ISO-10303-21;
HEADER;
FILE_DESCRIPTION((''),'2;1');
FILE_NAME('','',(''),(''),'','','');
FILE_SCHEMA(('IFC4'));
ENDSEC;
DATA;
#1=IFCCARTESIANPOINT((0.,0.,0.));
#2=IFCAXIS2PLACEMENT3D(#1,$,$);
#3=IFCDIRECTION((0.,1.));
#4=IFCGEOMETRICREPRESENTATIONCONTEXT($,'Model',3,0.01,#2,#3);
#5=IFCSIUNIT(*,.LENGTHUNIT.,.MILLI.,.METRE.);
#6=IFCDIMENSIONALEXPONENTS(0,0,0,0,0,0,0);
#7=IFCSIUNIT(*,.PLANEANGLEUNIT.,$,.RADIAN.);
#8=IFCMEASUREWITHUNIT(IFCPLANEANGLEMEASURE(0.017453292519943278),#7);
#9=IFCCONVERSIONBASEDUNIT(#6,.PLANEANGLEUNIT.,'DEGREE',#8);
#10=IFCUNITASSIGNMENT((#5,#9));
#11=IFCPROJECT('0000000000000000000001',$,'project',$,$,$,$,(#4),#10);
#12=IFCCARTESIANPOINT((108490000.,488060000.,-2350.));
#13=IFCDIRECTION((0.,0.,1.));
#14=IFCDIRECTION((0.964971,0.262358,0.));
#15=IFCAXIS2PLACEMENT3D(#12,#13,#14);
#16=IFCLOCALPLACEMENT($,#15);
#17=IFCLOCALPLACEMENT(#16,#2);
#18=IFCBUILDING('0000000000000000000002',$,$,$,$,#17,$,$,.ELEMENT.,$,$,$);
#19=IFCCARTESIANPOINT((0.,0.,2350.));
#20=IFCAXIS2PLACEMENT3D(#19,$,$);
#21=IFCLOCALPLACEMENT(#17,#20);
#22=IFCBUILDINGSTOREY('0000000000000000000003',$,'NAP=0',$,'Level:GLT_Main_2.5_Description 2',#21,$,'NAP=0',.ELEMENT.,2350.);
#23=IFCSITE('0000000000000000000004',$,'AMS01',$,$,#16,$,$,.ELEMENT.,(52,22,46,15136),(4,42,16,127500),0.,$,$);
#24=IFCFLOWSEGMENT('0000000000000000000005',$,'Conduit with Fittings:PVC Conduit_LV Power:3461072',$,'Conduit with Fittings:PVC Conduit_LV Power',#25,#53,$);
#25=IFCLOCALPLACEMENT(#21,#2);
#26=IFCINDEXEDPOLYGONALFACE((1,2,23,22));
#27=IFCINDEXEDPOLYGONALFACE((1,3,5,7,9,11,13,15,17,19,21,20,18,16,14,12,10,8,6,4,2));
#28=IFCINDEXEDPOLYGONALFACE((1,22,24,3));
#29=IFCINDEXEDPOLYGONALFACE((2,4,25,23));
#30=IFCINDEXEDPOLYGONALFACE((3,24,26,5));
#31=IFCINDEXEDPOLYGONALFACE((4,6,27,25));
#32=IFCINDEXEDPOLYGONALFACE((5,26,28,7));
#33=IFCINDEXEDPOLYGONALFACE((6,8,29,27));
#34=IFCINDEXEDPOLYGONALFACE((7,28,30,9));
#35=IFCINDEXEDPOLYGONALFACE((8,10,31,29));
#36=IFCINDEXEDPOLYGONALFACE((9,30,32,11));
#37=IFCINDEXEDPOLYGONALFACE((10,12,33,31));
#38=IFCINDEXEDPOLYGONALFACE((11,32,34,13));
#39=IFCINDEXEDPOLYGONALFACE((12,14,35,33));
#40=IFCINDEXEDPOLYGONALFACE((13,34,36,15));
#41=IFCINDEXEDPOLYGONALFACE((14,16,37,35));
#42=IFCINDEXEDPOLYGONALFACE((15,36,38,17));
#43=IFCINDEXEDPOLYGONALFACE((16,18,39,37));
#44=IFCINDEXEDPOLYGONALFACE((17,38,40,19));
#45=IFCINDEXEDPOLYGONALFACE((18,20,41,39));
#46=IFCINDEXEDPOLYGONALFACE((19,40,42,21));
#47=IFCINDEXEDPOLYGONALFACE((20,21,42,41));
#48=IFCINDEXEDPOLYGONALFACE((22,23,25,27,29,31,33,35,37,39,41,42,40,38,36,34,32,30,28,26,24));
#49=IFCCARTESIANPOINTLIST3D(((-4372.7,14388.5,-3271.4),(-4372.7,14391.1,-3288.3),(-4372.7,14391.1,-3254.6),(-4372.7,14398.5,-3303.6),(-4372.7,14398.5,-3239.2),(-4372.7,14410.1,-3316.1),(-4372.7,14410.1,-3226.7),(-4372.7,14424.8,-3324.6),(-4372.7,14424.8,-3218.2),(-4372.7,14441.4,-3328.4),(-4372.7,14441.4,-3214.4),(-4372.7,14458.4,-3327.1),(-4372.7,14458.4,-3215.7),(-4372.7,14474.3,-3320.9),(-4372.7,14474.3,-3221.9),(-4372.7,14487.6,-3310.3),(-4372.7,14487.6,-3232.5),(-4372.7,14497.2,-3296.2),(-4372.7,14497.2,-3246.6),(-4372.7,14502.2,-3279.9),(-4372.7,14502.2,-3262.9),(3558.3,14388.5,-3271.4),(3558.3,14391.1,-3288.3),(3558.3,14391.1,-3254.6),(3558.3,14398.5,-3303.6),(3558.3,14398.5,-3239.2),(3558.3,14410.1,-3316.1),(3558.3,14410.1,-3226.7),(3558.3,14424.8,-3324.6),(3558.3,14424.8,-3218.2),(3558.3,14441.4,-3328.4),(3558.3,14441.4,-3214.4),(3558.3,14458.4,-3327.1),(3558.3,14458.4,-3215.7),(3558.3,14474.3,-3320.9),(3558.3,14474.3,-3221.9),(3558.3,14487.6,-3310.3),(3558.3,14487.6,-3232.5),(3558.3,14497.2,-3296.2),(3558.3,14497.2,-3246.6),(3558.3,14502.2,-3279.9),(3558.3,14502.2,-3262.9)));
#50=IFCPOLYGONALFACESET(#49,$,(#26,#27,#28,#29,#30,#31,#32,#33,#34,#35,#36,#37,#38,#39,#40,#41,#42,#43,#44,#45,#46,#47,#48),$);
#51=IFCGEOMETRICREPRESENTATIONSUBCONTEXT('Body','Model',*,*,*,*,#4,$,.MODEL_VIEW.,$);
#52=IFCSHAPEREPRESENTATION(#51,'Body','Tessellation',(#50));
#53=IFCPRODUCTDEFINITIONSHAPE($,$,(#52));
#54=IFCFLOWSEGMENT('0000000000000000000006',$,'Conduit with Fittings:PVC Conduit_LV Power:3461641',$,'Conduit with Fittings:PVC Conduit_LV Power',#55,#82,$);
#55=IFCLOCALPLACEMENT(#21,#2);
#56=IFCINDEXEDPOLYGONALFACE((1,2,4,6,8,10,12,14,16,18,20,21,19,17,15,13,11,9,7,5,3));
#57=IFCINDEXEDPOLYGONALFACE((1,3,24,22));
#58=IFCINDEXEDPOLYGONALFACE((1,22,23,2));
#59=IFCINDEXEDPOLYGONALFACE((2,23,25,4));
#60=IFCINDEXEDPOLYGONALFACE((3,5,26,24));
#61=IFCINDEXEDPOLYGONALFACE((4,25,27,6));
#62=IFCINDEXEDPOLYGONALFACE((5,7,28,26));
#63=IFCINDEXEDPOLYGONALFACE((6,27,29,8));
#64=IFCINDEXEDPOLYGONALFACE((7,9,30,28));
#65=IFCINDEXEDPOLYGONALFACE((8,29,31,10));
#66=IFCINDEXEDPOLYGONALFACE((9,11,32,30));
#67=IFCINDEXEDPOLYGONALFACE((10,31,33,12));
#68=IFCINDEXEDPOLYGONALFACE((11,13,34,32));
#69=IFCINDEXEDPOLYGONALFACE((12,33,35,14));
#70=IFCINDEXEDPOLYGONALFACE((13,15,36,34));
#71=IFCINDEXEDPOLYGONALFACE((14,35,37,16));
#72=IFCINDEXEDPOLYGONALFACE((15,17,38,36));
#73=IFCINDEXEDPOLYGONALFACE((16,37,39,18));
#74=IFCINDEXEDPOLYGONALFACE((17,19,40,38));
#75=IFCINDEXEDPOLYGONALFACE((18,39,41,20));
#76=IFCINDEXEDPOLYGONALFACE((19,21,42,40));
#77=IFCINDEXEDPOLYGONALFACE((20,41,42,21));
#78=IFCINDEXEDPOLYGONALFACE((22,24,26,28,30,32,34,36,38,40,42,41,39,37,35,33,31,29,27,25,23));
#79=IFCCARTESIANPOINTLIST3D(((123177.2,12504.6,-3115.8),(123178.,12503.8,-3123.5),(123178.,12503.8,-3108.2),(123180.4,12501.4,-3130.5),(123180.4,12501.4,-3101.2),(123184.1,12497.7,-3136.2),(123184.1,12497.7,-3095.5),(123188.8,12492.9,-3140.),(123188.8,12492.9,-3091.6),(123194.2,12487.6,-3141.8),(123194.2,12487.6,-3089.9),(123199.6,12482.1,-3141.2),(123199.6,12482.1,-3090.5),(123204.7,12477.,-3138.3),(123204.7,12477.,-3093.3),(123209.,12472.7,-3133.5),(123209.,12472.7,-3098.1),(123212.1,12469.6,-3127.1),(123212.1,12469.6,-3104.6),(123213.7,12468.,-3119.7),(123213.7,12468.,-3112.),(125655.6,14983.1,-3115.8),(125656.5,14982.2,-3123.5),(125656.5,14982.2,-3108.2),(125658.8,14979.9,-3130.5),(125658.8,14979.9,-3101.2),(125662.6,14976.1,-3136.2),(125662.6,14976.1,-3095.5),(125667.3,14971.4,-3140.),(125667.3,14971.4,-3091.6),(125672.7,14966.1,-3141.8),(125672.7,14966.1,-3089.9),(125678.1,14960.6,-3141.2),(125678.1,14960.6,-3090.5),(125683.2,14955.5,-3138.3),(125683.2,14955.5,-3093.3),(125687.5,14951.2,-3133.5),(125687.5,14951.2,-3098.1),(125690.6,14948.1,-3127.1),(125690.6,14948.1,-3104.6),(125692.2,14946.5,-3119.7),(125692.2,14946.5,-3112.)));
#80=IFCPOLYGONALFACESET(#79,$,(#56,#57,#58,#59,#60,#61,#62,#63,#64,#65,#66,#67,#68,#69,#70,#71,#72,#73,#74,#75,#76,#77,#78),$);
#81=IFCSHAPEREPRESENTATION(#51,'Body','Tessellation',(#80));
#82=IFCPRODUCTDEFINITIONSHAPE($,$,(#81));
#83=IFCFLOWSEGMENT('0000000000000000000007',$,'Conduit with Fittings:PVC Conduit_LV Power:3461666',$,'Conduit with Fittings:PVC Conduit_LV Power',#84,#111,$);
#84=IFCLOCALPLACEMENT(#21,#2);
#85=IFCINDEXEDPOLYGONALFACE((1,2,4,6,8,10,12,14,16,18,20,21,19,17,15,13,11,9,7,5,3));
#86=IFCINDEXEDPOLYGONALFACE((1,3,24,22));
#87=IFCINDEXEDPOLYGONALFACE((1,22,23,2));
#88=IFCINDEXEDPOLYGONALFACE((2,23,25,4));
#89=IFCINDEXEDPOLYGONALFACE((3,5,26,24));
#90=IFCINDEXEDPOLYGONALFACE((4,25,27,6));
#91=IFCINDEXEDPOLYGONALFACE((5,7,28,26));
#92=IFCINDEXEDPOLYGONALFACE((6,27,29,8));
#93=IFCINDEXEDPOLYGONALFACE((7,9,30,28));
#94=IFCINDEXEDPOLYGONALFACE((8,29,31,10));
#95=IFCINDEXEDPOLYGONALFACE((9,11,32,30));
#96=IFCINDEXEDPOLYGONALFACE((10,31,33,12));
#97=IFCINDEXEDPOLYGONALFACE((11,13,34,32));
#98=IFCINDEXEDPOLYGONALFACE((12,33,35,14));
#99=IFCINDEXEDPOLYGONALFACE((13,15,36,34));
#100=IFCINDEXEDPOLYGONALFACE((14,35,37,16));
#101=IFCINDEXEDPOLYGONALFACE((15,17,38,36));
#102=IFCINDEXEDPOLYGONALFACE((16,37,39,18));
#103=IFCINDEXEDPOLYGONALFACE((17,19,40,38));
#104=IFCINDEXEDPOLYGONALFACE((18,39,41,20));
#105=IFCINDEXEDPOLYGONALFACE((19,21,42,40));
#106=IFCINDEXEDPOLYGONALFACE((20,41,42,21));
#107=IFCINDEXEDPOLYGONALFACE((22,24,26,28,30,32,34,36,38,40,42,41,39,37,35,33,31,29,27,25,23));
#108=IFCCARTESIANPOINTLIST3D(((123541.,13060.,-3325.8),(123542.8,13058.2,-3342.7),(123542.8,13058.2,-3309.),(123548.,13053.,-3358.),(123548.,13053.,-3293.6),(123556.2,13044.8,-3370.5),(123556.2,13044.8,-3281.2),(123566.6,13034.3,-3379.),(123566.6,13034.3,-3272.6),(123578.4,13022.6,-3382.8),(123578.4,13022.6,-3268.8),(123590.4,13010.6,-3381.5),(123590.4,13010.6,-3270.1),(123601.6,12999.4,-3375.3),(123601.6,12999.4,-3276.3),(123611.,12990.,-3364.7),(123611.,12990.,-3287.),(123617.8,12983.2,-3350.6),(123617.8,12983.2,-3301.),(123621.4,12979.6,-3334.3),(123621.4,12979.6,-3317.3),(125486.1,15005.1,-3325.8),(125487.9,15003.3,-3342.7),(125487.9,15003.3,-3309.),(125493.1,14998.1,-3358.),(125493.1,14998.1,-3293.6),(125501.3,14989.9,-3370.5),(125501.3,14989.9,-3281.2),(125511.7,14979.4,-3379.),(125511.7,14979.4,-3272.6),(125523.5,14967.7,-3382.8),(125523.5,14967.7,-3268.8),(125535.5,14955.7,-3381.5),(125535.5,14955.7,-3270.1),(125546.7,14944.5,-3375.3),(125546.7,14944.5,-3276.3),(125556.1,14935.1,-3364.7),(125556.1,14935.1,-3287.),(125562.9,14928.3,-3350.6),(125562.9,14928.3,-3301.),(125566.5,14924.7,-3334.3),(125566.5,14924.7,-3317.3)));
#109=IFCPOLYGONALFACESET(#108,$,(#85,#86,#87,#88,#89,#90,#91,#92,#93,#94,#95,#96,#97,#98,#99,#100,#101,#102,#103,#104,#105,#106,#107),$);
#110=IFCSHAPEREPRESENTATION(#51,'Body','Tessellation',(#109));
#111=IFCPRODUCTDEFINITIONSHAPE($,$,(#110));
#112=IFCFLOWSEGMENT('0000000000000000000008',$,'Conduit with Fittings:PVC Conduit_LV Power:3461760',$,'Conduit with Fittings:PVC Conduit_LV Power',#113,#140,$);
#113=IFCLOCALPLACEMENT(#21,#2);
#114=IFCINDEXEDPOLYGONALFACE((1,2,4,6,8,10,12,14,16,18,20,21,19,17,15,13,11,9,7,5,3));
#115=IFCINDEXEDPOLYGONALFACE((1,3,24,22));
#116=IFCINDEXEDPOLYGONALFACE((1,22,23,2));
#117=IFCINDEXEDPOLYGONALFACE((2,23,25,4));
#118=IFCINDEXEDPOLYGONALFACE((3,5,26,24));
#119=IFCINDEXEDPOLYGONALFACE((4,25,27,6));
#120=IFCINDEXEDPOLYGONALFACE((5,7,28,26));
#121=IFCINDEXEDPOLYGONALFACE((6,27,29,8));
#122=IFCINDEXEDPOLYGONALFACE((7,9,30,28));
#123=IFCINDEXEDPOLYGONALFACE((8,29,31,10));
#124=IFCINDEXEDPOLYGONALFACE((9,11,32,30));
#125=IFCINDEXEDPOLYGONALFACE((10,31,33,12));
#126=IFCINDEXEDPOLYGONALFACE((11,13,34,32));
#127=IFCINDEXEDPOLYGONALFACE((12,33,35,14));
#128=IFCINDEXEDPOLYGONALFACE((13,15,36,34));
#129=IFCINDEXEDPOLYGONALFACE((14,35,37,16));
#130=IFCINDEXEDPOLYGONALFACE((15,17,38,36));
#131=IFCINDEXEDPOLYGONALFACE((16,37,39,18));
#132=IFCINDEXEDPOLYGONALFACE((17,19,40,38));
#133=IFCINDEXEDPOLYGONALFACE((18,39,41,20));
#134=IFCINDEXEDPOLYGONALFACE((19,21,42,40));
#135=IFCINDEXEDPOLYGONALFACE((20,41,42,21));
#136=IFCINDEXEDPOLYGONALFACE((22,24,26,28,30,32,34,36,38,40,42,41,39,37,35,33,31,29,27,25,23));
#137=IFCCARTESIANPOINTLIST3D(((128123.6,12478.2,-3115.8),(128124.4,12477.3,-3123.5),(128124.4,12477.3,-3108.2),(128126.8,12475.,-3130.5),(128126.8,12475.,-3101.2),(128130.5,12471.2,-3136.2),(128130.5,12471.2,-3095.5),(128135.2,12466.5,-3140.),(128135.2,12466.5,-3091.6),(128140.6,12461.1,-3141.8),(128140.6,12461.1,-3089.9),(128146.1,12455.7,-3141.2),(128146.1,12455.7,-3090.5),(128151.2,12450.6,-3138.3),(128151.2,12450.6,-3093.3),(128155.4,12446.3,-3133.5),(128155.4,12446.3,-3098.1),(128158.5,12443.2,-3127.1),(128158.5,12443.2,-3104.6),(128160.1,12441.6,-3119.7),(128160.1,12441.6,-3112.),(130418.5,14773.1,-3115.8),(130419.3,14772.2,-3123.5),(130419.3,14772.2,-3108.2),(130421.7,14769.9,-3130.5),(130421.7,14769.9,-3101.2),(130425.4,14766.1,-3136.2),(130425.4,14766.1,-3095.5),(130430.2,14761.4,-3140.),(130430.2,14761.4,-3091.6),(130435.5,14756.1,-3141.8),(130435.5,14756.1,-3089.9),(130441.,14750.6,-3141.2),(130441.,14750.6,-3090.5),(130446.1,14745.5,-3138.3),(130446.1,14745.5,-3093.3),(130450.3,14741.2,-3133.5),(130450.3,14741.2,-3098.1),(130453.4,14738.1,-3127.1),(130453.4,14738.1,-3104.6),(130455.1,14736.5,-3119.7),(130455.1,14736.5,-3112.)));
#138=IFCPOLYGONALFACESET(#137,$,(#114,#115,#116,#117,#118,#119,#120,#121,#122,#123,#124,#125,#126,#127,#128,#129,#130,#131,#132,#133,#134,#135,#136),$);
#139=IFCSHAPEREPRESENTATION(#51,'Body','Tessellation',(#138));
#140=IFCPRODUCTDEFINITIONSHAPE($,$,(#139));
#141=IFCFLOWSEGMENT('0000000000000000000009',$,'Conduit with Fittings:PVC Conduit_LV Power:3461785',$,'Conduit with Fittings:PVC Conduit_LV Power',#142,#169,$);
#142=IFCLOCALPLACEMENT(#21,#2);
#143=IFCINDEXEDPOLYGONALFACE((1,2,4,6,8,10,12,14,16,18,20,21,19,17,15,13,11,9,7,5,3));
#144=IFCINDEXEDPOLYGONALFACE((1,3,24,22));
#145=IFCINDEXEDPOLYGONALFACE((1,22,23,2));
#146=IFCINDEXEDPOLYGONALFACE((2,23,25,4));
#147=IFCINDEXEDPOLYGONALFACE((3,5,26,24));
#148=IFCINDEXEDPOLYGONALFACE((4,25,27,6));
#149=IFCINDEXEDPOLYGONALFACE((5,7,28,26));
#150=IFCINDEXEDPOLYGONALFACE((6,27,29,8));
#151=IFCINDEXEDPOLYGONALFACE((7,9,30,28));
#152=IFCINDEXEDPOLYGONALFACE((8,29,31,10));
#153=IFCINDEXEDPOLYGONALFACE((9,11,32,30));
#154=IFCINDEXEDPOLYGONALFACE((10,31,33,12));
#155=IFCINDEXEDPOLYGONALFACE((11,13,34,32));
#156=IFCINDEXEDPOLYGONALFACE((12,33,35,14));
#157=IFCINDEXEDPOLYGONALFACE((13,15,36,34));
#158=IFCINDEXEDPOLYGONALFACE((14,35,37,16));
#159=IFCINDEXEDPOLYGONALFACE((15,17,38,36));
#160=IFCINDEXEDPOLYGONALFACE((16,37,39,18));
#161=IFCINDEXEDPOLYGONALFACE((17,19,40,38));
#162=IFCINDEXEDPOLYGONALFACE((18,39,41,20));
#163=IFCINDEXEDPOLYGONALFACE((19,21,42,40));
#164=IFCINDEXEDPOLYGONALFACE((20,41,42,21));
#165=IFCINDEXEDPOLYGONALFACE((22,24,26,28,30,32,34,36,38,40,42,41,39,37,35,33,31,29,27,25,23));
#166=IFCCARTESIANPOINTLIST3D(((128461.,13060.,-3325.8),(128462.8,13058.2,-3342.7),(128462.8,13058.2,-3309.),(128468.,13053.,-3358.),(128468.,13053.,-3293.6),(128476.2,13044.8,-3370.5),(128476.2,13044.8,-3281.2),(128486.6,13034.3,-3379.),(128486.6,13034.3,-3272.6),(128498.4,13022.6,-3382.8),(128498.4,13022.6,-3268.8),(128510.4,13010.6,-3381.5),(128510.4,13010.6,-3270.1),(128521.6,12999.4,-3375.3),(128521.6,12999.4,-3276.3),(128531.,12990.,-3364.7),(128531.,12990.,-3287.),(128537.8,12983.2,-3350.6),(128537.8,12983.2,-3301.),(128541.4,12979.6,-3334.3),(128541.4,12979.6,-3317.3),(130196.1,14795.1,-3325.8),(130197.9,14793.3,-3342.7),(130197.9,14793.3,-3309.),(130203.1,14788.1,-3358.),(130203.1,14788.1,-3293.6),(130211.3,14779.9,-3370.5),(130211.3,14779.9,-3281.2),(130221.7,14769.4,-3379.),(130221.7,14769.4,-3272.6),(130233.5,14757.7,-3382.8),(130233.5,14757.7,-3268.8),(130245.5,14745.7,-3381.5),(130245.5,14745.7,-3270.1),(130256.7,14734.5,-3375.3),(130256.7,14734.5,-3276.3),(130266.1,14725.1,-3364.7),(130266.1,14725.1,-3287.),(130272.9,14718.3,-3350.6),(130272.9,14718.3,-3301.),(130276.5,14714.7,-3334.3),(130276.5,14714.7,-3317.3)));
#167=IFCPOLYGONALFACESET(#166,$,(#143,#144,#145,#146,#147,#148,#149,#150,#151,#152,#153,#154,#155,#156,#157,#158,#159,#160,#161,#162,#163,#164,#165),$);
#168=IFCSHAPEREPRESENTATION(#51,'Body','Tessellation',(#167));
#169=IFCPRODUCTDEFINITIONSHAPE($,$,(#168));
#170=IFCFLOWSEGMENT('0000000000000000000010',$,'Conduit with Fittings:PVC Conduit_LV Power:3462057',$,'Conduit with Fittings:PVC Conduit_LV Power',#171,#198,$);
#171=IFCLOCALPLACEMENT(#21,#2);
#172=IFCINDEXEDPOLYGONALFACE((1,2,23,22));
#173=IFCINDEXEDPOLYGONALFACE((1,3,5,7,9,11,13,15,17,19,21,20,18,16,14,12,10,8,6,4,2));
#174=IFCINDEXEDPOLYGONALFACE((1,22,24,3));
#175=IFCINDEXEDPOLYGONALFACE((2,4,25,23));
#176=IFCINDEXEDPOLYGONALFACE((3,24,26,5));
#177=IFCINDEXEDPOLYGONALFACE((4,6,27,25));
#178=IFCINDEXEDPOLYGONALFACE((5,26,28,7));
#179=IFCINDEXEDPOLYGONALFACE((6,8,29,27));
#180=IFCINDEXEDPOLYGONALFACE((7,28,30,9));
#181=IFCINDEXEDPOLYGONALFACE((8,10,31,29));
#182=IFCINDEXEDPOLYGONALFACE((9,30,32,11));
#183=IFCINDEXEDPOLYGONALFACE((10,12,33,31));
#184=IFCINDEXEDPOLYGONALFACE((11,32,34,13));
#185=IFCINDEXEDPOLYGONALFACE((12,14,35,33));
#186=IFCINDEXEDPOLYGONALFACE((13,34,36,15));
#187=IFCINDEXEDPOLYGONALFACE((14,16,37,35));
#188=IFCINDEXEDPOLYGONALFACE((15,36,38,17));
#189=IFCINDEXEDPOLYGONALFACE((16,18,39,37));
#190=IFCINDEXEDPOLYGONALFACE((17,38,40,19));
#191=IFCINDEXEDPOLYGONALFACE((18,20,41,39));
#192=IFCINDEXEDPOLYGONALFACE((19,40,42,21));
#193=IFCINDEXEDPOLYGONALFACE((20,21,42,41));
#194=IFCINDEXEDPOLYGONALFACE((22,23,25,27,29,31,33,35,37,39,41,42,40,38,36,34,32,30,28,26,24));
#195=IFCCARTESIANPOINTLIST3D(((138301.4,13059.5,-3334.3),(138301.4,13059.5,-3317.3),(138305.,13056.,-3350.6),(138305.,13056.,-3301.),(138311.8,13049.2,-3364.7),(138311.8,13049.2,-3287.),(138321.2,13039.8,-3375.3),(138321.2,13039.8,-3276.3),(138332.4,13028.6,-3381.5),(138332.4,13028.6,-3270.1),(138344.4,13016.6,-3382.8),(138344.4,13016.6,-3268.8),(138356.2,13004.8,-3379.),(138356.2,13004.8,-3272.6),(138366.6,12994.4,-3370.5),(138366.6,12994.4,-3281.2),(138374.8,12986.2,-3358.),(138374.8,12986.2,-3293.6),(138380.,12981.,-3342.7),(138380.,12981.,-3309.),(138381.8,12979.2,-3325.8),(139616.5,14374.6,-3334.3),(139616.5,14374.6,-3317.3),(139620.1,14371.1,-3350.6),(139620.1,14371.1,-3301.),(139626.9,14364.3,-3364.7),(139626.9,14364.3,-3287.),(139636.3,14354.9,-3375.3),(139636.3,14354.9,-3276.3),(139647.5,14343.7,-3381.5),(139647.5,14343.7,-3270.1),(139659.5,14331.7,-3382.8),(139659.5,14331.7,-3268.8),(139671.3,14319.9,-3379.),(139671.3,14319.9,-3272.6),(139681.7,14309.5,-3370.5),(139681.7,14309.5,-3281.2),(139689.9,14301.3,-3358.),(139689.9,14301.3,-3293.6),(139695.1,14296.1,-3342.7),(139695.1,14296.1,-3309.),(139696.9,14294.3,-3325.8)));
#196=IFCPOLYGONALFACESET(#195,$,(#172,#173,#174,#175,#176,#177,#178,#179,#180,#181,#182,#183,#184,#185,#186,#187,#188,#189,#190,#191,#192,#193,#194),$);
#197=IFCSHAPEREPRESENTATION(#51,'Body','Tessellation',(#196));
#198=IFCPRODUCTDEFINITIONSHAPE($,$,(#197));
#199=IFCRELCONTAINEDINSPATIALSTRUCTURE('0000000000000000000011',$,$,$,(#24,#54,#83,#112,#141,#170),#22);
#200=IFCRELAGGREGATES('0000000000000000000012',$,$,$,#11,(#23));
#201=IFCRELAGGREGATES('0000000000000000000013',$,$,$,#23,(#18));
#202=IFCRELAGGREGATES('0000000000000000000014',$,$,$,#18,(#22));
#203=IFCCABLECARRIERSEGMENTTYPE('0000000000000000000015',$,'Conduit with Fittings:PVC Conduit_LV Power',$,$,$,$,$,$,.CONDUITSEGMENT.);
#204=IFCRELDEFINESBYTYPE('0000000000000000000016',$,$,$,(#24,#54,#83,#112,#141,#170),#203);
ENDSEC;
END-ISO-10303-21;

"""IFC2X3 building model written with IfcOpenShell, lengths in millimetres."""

from ifc_helpers import new_model, entity, si_unit, converted_unit, direction, frame, frame_2d, origin, origin_2d_with_axis, place, context, subcontext, project, spatial, circle, extrude, type_object, element, save


model = new_model("IFC2X3")

# Units and contexts
model_context = context("Model", 3, precision=0.01, world=origin(), true_north=direction((0.0, 1.0)))
body_context = subcontext(model_context, "Body", "Model", "MODEL_VIEW")
ifc_project = project(units=[si_unit("LENGTHUNIT", "METRE", prefix="MILLI"), converted_unit("PLANEANGLEUNIT", "DEGREE", entity("IfcPlaneAngleMeasure", 0.017453292519943278), si_unit("PLANEANGLEUNIT", "RADIAN"), dimensions=[0, 0, 0, 0, 0, 0, 0])], contexts=[model_context])

# Site, building, storey
site_placement = place(None, frame((108490000.0, 488060000.0, -2350.0), z_axis=(0.0, 0.0, 1.0), x_axis=(0.964971, 0.262358, 0.0)))
site = spatial("IfcSite", under=ifc_project, at=site_placement, Name="AMS01", CompositionType="ELEMENT", RefLatitude=(52, 22, 46, 15136), RefLongitude=(4, 42, 16, 127500), RefElevation=0.0)
building_placement = place(site_placement, origin())
building = spatial("IfcBuilding", under=site, at=building_placement, CompositionType="ELEMENT")
storey_placement = place(building_placement, frame((0.0, 0.0, 2350.0)))
storey = spatial("IfcBuildingStorey", under=building, at=storey_placement, Name="NAP=0", ObjectType="Level:GLT_Main_2.5_Description 2", LongName="NAP=0", CompositionType="ELEMENT", Elevation=2350.0)

# Flow segments
cable_carrier_segment_type = type_object("IfcCableCarrierSegmentType", Name="Conduit with Fittings:PVC Conduit_LV Power", PredefinedType="CONDUITSEGMENT")
flow_segment_1_placement = place(storey_placement, origin())
element("IfcFlowSegment", 1, at=flow_segment_1_placement, inside=storey, type_object=cable_carrier_segment_type, Name="Conduit with Fittings:PVC Conduit_LV Power:3461072", ObjectType="Conduit with Fittings:PVC Conduit_LV Power", context=body_context, shape_type="SweptSolid", body=[
    extrude(circle(Radius=57.2, at=frame_2d((0.0, 0.0), x_axis=(1.0, 0.0))), frame((-4372.7, 14445.7, -3271.4), z_axis=(1.0, 0.0, 0.0), x_axis=(0.0, -1.0, 0.0)), (0.0, 0.0, 1.0), 7931.0),
])
flow_segment_2_placement = place(storey_placement, origin())
element("IfcFlowSegment", 2, at=flow_segment_2_placement, inside=storey, type_object=cable_carrier_segment_type, Name="Conduit with Fittings:PVC Conduit_LV Power:3461641", ObjectType="Conduit with Fittings:PVC Conduit_LV Power", context=body_context, shape_type="SweptSolid", body=[
    extrude(circle(Radius=26.0, at=origin_2d_with_axis()), frame((123195.5, 12486.2, -3115.8), z_axis=(0.707107, 0.707107, 0.0), x_axis=(-0.707107, 0.707107, 0.0)), (0.0, 0.0, 1.0), 3505.1),
])
flow_segment_3_placement = place(storey_placement, origin())
element("IfcFlowSegment", 3, at=flow_segment_3_placement, inside=storey, type_object=cable_carrier_segment_type, Name="Conduit with Fittings:PVC Conduit_LV Power:3461666", ObjectType="Conduit with Fittings:PVC Conduit_LV Power", context=body_context, shape_type="SweptSolid", body=[
    extrude(circle(Radius=57.2, at=frame_2d((0.0, 0.0), x_axis=(1.0, 0.0))), frame((123581.4, 13019.6, -3325.8), z_axis=(0.707107, 0.707107, 0.0), x_axis=(-0.707107, 0.707107, 0.0)), (0.0, 0.0, 1.0), 2750.8),
])
flow_segment_4_placement = place(storey_placement, origin())
element("IfcFlowSegment", 4, at=flow_segment_4_placement, inside=storey, type_object=cable_carrier_segment_type, Name="Conduit with Fittings:PVC Conduit_LV Power:3461760", ObjectType="Conduit with Fittings:PVC Conduit_LV Power", context=body_context, shape_type="SweptSolid", body=[
    extrude(circle(Radius=26.0, at=frame_2d((0.0, 0.0), x_axis=(1.0, 0.0))), frame((128142.0, 12459.8, -3115.8), z_axis=(0.707107, 0.707107, 0.0), x_axis=(-0.707107, 0.707107, 0.0)), (0.0, 0.0, 1.0), 3245.5),
])
flow_segment_5_placement = place(storey_placement, origin())
element("IfcFlowSegment", 5, at=flow_segment_5_placement, inside=storey, type_object=cable_carrier_segment_type, Name="Conduit with Fittings:PVC Conduit_LV Power:3461785", ObjectType="Conduit with Fittings:PVC Conduit_LV Power", context=body_context, shape_type="SweptSolid", body=[
    extrude(circle(Radius=57.2, at=frame_2d((0.0, 0.0), x_axis=(1.0, 0.0))), frame((128501.4, 13019.6, -3325.8), z_axis=(0.707107, 0.707107, 0.0), x_axis=(-0.707107, 0.707107, 0.0)), (0.0, 0.0, 1.0), 2453.8),
])
flow_segment_6_placement = place(storey_placement, origin())
element("IfcFlowSegment", 6, at=flow_segment_6_placement, inside=storey, type_object=cable_carrier_segment_type, Name="Conduit with Fittings:PVC Conduit_LV Power:3462057", ObjectType="Conduit with Fittings:PVC Conduit_LV Power", context=body_context, shape_type="SweptSolid", body=[
    extrude(circle(Radius=57.2, at=origin_2d_with_axis()), frame((138341.4, 13019.6, -3325.8), z_axis=(0.707107, 0.707107, 0.0), x_axis=(0.707107, -0.707107, 0.0)), (0.0, 0.0, 1.0), 1859.8),
])

save(model, "model.ifc")
